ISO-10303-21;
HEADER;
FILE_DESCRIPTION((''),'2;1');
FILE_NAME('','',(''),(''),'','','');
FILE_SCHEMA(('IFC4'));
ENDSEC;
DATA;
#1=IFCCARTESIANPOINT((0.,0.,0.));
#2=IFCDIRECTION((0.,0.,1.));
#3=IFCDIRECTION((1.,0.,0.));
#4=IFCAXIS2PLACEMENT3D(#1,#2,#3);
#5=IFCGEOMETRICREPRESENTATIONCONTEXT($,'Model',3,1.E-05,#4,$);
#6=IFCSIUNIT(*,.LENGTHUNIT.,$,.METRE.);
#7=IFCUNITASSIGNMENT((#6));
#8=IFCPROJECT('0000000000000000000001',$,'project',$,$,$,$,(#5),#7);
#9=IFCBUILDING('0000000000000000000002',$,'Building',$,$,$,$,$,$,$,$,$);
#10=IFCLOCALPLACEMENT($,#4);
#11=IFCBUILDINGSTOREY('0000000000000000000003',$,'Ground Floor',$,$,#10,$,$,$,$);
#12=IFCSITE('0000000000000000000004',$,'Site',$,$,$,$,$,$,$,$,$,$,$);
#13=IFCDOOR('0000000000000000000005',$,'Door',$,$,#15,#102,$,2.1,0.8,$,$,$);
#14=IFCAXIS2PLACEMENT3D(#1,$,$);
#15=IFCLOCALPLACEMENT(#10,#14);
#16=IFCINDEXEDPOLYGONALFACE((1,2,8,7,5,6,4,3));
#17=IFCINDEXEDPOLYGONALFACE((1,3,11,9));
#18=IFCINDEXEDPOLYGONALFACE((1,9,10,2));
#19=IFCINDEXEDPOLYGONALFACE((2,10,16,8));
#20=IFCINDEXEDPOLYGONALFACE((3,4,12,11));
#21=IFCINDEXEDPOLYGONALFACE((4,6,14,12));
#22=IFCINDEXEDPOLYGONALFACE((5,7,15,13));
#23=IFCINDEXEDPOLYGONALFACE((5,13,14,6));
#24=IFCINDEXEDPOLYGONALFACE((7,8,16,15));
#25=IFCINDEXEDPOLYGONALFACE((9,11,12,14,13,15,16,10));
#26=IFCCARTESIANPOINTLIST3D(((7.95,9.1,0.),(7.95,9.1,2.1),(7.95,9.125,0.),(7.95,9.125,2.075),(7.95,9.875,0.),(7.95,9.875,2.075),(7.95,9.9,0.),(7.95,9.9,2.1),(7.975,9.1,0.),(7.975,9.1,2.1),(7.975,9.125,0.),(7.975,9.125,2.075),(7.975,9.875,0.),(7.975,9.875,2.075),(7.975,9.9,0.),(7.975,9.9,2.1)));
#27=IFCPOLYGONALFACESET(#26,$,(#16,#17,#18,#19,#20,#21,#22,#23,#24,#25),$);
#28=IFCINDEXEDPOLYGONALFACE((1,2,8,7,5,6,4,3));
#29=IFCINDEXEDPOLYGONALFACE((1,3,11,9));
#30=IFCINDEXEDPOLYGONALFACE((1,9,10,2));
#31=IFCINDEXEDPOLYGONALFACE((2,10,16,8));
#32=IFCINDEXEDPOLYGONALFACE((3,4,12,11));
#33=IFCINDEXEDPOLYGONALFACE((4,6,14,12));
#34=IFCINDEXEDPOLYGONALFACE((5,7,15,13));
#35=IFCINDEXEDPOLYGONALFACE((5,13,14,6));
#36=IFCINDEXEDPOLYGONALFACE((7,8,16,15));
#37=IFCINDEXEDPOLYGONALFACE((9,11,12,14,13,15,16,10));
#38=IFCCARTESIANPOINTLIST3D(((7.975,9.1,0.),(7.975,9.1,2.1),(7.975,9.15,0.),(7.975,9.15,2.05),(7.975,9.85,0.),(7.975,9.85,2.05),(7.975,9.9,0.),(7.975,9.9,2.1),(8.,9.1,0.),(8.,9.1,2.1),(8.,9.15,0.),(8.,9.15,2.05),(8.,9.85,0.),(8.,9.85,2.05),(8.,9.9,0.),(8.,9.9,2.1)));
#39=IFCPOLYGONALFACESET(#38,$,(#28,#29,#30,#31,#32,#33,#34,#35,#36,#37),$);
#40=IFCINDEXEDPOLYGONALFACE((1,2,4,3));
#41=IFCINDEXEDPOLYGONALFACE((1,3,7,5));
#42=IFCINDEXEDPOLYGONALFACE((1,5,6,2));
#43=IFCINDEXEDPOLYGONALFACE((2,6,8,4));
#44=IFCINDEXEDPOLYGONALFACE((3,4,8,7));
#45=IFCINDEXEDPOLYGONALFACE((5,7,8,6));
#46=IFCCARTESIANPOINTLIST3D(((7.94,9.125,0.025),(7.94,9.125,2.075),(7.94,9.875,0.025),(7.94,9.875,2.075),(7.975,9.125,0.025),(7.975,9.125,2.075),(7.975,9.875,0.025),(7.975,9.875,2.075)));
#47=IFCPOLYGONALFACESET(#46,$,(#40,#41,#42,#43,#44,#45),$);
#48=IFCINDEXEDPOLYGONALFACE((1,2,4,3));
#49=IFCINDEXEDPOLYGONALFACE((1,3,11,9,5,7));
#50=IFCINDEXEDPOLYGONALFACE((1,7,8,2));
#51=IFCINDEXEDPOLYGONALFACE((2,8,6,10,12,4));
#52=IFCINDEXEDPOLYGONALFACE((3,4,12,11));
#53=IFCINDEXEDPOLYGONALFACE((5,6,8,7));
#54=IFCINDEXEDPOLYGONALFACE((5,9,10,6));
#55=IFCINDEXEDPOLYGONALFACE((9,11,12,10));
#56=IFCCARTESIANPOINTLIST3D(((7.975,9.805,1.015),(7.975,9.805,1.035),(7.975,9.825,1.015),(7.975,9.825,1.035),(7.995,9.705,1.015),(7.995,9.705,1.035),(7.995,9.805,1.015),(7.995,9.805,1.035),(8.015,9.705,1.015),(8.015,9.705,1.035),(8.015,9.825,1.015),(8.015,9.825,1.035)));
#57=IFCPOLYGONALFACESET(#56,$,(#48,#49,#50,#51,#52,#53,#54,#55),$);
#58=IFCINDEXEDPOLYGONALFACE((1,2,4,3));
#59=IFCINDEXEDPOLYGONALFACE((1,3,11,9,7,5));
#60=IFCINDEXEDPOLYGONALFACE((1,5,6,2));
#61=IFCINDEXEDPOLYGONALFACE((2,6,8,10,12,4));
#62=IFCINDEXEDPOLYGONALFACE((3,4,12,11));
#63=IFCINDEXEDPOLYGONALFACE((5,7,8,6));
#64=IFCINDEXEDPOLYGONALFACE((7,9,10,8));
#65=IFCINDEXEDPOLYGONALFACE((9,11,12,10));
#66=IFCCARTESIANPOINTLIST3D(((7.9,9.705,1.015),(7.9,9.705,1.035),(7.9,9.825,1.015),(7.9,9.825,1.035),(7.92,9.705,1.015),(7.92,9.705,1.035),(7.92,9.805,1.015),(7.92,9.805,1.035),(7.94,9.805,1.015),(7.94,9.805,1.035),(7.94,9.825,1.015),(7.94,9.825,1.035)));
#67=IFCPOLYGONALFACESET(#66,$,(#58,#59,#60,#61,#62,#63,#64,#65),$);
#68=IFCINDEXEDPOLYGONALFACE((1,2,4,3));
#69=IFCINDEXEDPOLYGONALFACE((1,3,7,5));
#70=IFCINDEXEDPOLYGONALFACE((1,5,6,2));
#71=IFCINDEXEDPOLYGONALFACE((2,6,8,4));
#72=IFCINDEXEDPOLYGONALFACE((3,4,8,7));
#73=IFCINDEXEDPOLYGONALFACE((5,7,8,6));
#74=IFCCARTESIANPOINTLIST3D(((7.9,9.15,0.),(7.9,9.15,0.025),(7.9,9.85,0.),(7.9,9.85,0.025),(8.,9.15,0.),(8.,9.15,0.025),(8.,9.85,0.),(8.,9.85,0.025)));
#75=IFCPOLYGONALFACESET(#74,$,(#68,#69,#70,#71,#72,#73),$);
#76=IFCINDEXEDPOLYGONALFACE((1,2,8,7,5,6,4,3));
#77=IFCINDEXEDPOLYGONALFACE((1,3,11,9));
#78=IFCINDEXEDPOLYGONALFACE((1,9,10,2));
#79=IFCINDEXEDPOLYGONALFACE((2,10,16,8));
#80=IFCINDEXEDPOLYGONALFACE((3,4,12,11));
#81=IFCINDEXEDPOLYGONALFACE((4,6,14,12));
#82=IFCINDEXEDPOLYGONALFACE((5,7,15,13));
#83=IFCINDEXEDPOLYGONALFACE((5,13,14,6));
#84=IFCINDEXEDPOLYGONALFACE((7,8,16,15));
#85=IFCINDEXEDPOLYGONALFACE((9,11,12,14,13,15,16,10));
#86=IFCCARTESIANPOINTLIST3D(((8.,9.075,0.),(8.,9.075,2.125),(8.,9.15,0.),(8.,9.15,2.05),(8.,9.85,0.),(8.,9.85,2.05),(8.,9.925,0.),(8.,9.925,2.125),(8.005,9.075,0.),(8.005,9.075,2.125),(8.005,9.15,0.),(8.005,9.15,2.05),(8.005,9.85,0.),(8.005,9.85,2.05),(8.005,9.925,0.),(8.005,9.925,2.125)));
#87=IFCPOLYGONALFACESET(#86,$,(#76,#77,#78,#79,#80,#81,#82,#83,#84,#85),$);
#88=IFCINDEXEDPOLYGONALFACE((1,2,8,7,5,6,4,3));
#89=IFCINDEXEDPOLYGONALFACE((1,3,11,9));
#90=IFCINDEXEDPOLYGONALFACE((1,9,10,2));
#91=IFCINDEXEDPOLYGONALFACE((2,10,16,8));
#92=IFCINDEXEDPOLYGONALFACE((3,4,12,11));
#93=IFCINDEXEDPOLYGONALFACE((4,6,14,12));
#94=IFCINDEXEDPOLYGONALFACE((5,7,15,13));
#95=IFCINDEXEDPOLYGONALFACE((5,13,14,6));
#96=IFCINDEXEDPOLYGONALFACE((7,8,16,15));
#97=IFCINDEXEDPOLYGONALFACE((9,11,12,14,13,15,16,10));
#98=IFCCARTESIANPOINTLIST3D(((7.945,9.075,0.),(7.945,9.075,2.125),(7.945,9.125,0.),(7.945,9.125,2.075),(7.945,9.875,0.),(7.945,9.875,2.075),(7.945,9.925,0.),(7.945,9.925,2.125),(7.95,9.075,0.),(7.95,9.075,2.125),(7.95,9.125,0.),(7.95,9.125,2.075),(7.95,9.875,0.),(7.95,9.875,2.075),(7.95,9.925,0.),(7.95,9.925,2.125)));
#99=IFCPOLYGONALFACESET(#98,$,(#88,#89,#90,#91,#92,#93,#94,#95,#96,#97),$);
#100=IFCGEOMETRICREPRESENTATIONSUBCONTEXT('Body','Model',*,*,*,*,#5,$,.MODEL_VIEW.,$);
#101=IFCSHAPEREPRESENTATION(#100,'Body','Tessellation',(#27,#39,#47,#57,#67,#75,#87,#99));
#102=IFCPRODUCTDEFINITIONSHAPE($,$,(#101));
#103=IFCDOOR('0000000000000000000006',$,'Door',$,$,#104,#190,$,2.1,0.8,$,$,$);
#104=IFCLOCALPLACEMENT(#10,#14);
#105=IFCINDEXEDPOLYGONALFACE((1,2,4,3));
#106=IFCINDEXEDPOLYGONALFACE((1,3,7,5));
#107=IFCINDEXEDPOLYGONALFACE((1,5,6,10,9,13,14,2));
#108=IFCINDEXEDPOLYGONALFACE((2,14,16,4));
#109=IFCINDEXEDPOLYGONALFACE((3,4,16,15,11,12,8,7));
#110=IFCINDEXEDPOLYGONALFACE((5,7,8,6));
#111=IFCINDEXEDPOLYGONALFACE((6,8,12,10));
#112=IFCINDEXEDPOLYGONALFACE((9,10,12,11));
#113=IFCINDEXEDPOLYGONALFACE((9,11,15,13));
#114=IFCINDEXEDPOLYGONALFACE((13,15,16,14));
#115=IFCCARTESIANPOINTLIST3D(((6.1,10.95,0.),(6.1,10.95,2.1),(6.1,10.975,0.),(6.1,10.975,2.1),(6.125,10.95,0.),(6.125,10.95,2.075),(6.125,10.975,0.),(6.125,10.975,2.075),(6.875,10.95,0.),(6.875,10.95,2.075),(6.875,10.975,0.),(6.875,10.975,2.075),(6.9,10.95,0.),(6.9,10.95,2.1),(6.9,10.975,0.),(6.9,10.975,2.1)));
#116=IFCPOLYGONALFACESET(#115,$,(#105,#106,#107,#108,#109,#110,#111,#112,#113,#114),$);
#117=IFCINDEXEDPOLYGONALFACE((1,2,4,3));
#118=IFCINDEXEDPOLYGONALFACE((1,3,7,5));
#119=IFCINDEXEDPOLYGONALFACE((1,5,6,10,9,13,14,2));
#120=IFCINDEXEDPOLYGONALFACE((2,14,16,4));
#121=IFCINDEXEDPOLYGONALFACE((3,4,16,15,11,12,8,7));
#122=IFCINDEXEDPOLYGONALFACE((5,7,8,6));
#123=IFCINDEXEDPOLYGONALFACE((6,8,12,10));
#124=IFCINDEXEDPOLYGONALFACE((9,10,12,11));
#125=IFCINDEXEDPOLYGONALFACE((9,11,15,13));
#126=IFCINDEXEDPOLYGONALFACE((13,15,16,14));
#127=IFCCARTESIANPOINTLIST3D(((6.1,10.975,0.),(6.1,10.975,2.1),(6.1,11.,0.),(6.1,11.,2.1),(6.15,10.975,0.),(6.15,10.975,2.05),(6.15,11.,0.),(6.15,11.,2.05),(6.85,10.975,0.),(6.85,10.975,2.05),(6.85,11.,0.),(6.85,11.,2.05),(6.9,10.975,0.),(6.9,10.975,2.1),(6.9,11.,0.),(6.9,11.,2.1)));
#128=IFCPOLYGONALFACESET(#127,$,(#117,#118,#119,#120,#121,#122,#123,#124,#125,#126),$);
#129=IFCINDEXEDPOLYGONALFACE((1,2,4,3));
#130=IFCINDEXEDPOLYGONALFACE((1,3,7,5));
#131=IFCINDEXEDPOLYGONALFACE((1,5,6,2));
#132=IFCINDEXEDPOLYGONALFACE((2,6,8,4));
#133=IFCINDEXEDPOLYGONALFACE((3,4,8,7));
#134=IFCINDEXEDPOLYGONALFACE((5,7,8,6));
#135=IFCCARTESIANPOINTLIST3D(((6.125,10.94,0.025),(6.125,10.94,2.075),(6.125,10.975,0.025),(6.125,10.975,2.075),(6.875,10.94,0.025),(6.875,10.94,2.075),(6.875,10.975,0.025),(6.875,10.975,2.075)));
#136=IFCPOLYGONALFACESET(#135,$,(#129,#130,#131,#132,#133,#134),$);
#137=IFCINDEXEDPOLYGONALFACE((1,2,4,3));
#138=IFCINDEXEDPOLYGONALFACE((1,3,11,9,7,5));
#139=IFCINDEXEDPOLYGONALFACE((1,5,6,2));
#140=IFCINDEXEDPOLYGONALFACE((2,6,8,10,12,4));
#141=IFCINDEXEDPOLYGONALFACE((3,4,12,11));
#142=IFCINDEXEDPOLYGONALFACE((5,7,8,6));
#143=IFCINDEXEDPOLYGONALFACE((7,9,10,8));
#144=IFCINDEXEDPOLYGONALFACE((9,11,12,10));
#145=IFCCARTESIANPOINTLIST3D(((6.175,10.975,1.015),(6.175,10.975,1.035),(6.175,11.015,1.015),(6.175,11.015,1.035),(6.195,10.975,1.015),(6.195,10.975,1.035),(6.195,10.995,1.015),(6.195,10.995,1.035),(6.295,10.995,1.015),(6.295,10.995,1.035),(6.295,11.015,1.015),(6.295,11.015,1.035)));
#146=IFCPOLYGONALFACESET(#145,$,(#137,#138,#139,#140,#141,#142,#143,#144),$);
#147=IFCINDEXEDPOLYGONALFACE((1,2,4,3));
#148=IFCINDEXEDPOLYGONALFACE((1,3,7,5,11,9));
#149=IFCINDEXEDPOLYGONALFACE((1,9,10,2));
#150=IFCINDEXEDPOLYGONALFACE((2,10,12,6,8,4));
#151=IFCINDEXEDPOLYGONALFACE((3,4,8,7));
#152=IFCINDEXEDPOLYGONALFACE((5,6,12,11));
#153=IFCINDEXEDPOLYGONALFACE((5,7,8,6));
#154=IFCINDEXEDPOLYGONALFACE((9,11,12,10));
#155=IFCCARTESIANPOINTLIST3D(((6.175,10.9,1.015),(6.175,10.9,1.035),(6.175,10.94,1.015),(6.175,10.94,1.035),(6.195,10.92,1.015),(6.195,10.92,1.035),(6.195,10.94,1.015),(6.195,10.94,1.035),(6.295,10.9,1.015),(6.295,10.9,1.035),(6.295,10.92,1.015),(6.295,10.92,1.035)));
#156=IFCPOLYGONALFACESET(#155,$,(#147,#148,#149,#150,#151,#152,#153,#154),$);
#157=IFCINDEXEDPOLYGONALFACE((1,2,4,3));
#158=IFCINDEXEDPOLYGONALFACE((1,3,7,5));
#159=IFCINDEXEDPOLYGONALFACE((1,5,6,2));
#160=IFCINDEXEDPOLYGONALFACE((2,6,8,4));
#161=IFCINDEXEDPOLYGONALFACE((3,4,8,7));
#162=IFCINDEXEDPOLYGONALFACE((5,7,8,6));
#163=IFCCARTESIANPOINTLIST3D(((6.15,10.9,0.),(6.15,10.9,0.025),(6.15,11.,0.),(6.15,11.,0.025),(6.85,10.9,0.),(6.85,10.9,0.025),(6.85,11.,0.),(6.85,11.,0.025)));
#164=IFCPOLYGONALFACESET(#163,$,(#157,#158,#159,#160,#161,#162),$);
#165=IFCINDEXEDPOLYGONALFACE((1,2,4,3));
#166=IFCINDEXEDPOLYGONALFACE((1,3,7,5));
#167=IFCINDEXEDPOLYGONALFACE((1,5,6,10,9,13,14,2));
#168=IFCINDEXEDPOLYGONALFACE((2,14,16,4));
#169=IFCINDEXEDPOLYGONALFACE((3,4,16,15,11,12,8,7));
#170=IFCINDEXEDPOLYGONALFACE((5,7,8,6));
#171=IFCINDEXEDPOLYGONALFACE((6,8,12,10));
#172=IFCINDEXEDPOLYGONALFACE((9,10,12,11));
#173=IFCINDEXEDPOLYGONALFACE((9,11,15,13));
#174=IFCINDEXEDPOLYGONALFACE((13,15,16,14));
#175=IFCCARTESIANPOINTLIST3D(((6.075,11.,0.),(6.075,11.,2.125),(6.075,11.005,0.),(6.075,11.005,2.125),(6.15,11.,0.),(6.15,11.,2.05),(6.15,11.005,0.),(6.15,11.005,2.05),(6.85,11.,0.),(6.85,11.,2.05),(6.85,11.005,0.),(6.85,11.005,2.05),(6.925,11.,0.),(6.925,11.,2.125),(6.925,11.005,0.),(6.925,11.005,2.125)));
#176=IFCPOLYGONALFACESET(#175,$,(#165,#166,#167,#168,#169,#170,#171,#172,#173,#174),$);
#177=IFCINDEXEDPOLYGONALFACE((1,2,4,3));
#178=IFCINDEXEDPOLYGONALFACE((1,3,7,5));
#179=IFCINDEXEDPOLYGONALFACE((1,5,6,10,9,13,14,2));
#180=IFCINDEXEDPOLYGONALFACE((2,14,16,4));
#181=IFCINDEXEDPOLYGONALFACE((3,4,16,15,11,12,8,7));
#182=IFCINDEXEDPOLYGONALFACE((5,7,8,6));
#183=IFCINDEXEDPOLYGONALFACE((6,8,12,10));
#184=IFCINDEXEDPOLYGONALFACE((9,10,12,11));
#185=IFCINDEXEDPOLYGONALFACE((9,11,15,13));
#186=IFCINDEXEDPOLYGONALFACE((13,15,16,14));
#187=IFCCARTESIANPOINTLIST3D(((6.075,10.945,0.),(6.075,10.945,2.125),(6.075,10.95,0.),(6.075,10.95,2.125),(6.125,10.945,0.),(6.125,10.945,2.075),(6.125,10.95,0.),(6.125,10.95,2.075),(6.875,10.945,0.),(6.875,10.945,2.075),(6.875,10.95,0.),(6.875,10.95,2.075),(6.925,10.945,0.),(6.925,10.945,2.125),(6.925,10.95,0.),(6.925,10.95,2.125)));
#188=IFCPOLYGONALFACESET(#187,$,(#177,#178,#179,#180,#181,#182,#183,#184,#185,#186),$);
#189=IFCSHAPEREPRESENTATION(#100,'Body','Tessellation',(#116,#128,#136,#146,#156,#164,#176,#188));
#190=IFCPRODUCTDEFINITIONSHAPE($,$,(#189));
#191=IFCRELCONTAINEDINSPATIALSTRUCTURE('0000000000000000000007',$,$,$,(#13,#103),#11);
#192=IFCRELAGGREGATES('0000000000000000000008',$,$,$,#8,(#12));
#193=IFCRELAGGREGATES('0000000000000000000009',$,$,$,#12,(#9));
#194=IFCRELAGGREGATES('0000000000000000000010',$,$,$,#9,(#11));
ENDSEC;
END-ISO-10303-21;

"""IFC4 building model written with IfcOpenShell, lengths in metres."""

from ifc_helpers import new_model, si_unit, frame, origin_with_axes, place, context, subcontext, project, spatial, line, indexed_curve, outline, extrude, element, save


model = new_model("IFC4")

# Units and contexts
model_context = context("Model", 3, precision=1e-05, world=origin_with_axes())
body_context = subcontext(model_context, "Body", "Model", "MODEL_VIEW")
ifc_project = project(units=[si_unit("LENGTHUNIT", "METRE")], contexts=[model_context])

# Site, building, storey
site = spatial("IfcSite", under=ifc_project, Name="Site")
building = spatial("IfcBuilding", under=site, Name="Building")
storey_placement = place(None, origin_with_axes())
storey = spatial("IfcBuildingStorey", under=building, at=storey_placement, Name="Ground Floor")

# Doors
door_1_placement = place(storey_placement, frame((8.0, 9.1, 0.0), z_axis=(0.0, 0.0, 1.0), x_axis=(0.0, 1.0, 0.0)))
element("IfcDoor", 1, at=door_1_placement, inside=storey, Name="Door", OverallHeight=2.1, OverallWidth=0.8, context=body_context, shape_type="SweptSolid", body=[
    extrude(outline(indexed_curve([(0.0, 0.0), (0.0, 2.1), (0.8, 2.1), (0.8, 0.0), (0.775, 0.0), (0.775, 2.075), (0.025, 2.075), (0.025, 0.0)], segments=[line(1, 2, 3, 4, 5, 6, 7, 8, 1)])), frame((0.0, 0.025, 0.0), z_axis=(0.0, -1.0, 0.0), x_axis=(1.0, 0.0, 0.0)), (0.0, 0.0, -1.0), 0.025),
    extrude(outline(indexed_curve([(0.0, 0.0), (0.0, 2.1), (0.8, 2.1), (0.8, 0.0), (0.75, 0.0), (0.75, 2.05), (0.05, 2.05), (0.05, 0.0)], segments=[line(1, 2, 3, 4, 5, 6, 7, 8, 1)])), frame((0.0, 0.0, 0.0), z_axis=(0.0, -1.0, 0.0), x_axis=(1.0, 0.0, 0.0)), (0.0, 0.0, -1.0), 0.025),
    extrude(outline(indexed_curve([(0.0, 0.0), (0.75, 0.0), (0.75, 0.035), (0.0, 0.035)], segments=[line(1, 2, 3, 4, 1)])), frame((0.025, 0.025, 0.025), z_axis=(0.0, 0.0, 1.0), x_axis=(1.0, 0.0, 0.0)), (0.0, 0.0, 1.0), 2.05),
    extrude(outline(indexed_curve([(0.0, 0.0), (0.0, -0.04), (-0.12, -0.04), (-0.12, -0.02), (-0.02, -0.02), (-0.02, 0.0)], segments=[line(1, 2, 3, 4, 5, 6, 1)])), frame((0.725, 0.025, 1.015), z_axis=(0.0, 0.0, 1.0), x_axis=(1.0, 0.0, 0.0)), (0.0, 0.0, 1.0), 0.02),
    extrude(outline(indexed_curve([(0.0, 0.0), (0.0, 0.04), (-0.12, 0.04), (-0.12, 0.02), (-0.02, 0.02), (-0.02, 0.0)], segments=[line(1, 2, 3, 4, 5, 6, 1)])), frame((0.725, 0.06, 1.015), z_axis=(0.0, 0.0, 1.0), x_axis=(1.0, 0.0, 0.0)), (0.0, 0.0, 1.0), 0.02),
    extrude(outline(indexed_curve([(0.0, 0.0), (0.7, 0.0), (0.7, 0.1), (0.0, 0.1)], segments=[line(1, 2, 3, 4, 1)])), frame((0.05, 0.0, 0.0), z_axis=(0.0, 0.0, 1.0), x_axis=(1.0, 0.0, 0.0)), (0.0, 0.0, 1.0), 0.025),
    extrude(outline(indexed_curve([(0.0, 0.0), (0.0, 2.125), (0.85, 2.125), (0.85, 0.0), (0.775, 0.0), (0.775, 2.05), (0.075, 2.05), (0.075, 0.0)], segments=[line(1, 2, 3, 4, 5, 6, 7, 8, 1)])), frame((-0.025, -0.005, 0.0), z_axis=(0.0, -1.0, 0.0), x_axis=(1.0, 0.0, 0.0)), (0.0, 0.0, -1.0), 0.005),
    extrude(outline(indexed_curve([(0.0, 0.0), (0.0, 2.125), (0.85, 2.125), (0.85, 0.0), (0.8, 0.0), (0.8, 2.075), (0.05, 2.075), (0.05, 0.0)], segments=[line(1, 2, 3, 4, 5, 6, 7, 8, 1)])), frame((-0.025, 0.05, 0.0), z_axis=(0.0, -1.0, 0.0), x_axis=(1.0, 0.0, 0.0)), (0.0, 0.0, -1.0), 0.005),
])
door_2_placement = place(storey_placement, frame((6.9, 11.0, 0.0), z_axis=(0.0, 0.0, 1.0), x_axis=(-1.0, 0.0, 0.0)))
element("IfcDoor", 2, at=door_2_placement, inside=storey, Name="Door", OverallHeight=2.1, OverallWidth=0.8, context=body_context, shape_type="SweptSolid", body=[
    extrude(outline(indexed_curve([(0.0, 0.0), (0.0, 2.1), (0.8, 2.1), (0.8, 0.0), (0.775, 0.0), (0.775, 2.075), (0.025, 2.075), (0.025, 0.0)], segments=[line(1, 2, 3, 4, 5, 6, 7, 8, 1)])), frame((0.0, 0.025, 0.0), z_axis=(0.0, -1.0, 0.0), x_axis=(1.0, 0.0, 0.0)), (0.0, 0.0, -1.0), 0.025),
    extrude(outline(indexed_curve([(0.0, 0.0), (0.0, 2.1), (0.8, 2.1), (0.8, 0.0), (0.75, 0.0), (0.75, 2.05), (0.05, 2.05), (0.05, 0.0)], segments=[line(1, 2, 3, 4, 5, 6, 7, 8, 1)])), frame((0.0, 0.0, 0.0), z_axis=(0.0, -1.0, 0.0), x_axis=(1.0, 0.0, 0.0)), (0.0, 0.0, -1.0), 0.025),
    extrude(outline(indexed_curve([(0.0, 0.0), (0.75, 0.0), (0.75, 0.035), (0.0, 0.035)], segments=[line(1, 2, 3, 4, 1)])), frame((0.025, 0.025, 0.025), z_axis=(0.0, 0.0, 1.0), x_axis=(1.0, 0.0, 0.0)), (0.0, 0.0, 1.0), 2.05),
    extrude(outline(indexed_curve([(0.0, 0.0), (0.0, -0.04), (-0.12, -0.04), (-0.12, -0.02), (-0.02, -0.02), (-0.02, 0.0)], segments=[line(1, 2, 3, 4, 5, 6, 1)])), frame((0.725, 0.025, 1.015), z_axis=(0.0, 0.0, 1.0), x_axis=(1.0, 0.0, 0.0)), (0.0, 0.0, 1.0), 0.02),
    extrude(outline(indexed_curve([(0.0, 0.0), (0.0, 0.04), (-0.12, 0.04), (-0.12, 0.02), (-0.02, 0.02), (-0.02, 0.0)], segments=[line(1, 2, 3, 4, 5, 6, 1)])), frame((0.725, 0.06, 1.015), z_axis=(0.0, 0.0, 1.0), x_axis=(1.0, 0.0, 0.0)), (0.0, 0.0, 1.0), 0.02),
    extrude(outline(indexed_curve([(0.0, 0.0), (0.7, 0.0), (0.7, 0.1), (0.0, 0.1)], segments=[line(1, 2, 3, 4, 1)])), frame((0.05, 0.0, 0.0), z_axis=(0.0, 0.0, 1.0), x_axis=(1.0, 0.0, 0.0)), (0.0, 0.0, 1.0), 0.025),
    extrude(outline(indexed_curve([(0.0, 0.0), (0.0, 2.125), (0.85, 2.125), (0.85, 0.0), (0.775, 0.0), (0.775, 2.05), (0.075, 2.05), (0.075, 0.0)], segments=[line(1, 2, 3, 4, 5, 6, 7, 8, 1)])), frame((-0.025, -0.005, 0.0), z_axis=(0.0, -1.0, 0.0), x_axis=(1.0, 0.0, 0.0)), (0.0, 0.0, -1.0), 0.005),
    extrude(outline(indexed_curve([(0.0, 0.0), (0.0, 2.125), (0.85, 2.125), (0.85, 0.0), (0.8, 0.0), (0.8, 2.075), (0.05, 2.075), (0.05, 0.0)], segments=[line(1, 2, 3, 4, 5, 6, 7, 8, 1)])), frame((-0.025, 0.05, 0.0), z_axis=(0.0, -1.0, 0.0), x_axis=(1.0, 0.0, 0.0)), (0.0, 0.0, -1.0), 0.005),
])

save(model, "model.ifc")
